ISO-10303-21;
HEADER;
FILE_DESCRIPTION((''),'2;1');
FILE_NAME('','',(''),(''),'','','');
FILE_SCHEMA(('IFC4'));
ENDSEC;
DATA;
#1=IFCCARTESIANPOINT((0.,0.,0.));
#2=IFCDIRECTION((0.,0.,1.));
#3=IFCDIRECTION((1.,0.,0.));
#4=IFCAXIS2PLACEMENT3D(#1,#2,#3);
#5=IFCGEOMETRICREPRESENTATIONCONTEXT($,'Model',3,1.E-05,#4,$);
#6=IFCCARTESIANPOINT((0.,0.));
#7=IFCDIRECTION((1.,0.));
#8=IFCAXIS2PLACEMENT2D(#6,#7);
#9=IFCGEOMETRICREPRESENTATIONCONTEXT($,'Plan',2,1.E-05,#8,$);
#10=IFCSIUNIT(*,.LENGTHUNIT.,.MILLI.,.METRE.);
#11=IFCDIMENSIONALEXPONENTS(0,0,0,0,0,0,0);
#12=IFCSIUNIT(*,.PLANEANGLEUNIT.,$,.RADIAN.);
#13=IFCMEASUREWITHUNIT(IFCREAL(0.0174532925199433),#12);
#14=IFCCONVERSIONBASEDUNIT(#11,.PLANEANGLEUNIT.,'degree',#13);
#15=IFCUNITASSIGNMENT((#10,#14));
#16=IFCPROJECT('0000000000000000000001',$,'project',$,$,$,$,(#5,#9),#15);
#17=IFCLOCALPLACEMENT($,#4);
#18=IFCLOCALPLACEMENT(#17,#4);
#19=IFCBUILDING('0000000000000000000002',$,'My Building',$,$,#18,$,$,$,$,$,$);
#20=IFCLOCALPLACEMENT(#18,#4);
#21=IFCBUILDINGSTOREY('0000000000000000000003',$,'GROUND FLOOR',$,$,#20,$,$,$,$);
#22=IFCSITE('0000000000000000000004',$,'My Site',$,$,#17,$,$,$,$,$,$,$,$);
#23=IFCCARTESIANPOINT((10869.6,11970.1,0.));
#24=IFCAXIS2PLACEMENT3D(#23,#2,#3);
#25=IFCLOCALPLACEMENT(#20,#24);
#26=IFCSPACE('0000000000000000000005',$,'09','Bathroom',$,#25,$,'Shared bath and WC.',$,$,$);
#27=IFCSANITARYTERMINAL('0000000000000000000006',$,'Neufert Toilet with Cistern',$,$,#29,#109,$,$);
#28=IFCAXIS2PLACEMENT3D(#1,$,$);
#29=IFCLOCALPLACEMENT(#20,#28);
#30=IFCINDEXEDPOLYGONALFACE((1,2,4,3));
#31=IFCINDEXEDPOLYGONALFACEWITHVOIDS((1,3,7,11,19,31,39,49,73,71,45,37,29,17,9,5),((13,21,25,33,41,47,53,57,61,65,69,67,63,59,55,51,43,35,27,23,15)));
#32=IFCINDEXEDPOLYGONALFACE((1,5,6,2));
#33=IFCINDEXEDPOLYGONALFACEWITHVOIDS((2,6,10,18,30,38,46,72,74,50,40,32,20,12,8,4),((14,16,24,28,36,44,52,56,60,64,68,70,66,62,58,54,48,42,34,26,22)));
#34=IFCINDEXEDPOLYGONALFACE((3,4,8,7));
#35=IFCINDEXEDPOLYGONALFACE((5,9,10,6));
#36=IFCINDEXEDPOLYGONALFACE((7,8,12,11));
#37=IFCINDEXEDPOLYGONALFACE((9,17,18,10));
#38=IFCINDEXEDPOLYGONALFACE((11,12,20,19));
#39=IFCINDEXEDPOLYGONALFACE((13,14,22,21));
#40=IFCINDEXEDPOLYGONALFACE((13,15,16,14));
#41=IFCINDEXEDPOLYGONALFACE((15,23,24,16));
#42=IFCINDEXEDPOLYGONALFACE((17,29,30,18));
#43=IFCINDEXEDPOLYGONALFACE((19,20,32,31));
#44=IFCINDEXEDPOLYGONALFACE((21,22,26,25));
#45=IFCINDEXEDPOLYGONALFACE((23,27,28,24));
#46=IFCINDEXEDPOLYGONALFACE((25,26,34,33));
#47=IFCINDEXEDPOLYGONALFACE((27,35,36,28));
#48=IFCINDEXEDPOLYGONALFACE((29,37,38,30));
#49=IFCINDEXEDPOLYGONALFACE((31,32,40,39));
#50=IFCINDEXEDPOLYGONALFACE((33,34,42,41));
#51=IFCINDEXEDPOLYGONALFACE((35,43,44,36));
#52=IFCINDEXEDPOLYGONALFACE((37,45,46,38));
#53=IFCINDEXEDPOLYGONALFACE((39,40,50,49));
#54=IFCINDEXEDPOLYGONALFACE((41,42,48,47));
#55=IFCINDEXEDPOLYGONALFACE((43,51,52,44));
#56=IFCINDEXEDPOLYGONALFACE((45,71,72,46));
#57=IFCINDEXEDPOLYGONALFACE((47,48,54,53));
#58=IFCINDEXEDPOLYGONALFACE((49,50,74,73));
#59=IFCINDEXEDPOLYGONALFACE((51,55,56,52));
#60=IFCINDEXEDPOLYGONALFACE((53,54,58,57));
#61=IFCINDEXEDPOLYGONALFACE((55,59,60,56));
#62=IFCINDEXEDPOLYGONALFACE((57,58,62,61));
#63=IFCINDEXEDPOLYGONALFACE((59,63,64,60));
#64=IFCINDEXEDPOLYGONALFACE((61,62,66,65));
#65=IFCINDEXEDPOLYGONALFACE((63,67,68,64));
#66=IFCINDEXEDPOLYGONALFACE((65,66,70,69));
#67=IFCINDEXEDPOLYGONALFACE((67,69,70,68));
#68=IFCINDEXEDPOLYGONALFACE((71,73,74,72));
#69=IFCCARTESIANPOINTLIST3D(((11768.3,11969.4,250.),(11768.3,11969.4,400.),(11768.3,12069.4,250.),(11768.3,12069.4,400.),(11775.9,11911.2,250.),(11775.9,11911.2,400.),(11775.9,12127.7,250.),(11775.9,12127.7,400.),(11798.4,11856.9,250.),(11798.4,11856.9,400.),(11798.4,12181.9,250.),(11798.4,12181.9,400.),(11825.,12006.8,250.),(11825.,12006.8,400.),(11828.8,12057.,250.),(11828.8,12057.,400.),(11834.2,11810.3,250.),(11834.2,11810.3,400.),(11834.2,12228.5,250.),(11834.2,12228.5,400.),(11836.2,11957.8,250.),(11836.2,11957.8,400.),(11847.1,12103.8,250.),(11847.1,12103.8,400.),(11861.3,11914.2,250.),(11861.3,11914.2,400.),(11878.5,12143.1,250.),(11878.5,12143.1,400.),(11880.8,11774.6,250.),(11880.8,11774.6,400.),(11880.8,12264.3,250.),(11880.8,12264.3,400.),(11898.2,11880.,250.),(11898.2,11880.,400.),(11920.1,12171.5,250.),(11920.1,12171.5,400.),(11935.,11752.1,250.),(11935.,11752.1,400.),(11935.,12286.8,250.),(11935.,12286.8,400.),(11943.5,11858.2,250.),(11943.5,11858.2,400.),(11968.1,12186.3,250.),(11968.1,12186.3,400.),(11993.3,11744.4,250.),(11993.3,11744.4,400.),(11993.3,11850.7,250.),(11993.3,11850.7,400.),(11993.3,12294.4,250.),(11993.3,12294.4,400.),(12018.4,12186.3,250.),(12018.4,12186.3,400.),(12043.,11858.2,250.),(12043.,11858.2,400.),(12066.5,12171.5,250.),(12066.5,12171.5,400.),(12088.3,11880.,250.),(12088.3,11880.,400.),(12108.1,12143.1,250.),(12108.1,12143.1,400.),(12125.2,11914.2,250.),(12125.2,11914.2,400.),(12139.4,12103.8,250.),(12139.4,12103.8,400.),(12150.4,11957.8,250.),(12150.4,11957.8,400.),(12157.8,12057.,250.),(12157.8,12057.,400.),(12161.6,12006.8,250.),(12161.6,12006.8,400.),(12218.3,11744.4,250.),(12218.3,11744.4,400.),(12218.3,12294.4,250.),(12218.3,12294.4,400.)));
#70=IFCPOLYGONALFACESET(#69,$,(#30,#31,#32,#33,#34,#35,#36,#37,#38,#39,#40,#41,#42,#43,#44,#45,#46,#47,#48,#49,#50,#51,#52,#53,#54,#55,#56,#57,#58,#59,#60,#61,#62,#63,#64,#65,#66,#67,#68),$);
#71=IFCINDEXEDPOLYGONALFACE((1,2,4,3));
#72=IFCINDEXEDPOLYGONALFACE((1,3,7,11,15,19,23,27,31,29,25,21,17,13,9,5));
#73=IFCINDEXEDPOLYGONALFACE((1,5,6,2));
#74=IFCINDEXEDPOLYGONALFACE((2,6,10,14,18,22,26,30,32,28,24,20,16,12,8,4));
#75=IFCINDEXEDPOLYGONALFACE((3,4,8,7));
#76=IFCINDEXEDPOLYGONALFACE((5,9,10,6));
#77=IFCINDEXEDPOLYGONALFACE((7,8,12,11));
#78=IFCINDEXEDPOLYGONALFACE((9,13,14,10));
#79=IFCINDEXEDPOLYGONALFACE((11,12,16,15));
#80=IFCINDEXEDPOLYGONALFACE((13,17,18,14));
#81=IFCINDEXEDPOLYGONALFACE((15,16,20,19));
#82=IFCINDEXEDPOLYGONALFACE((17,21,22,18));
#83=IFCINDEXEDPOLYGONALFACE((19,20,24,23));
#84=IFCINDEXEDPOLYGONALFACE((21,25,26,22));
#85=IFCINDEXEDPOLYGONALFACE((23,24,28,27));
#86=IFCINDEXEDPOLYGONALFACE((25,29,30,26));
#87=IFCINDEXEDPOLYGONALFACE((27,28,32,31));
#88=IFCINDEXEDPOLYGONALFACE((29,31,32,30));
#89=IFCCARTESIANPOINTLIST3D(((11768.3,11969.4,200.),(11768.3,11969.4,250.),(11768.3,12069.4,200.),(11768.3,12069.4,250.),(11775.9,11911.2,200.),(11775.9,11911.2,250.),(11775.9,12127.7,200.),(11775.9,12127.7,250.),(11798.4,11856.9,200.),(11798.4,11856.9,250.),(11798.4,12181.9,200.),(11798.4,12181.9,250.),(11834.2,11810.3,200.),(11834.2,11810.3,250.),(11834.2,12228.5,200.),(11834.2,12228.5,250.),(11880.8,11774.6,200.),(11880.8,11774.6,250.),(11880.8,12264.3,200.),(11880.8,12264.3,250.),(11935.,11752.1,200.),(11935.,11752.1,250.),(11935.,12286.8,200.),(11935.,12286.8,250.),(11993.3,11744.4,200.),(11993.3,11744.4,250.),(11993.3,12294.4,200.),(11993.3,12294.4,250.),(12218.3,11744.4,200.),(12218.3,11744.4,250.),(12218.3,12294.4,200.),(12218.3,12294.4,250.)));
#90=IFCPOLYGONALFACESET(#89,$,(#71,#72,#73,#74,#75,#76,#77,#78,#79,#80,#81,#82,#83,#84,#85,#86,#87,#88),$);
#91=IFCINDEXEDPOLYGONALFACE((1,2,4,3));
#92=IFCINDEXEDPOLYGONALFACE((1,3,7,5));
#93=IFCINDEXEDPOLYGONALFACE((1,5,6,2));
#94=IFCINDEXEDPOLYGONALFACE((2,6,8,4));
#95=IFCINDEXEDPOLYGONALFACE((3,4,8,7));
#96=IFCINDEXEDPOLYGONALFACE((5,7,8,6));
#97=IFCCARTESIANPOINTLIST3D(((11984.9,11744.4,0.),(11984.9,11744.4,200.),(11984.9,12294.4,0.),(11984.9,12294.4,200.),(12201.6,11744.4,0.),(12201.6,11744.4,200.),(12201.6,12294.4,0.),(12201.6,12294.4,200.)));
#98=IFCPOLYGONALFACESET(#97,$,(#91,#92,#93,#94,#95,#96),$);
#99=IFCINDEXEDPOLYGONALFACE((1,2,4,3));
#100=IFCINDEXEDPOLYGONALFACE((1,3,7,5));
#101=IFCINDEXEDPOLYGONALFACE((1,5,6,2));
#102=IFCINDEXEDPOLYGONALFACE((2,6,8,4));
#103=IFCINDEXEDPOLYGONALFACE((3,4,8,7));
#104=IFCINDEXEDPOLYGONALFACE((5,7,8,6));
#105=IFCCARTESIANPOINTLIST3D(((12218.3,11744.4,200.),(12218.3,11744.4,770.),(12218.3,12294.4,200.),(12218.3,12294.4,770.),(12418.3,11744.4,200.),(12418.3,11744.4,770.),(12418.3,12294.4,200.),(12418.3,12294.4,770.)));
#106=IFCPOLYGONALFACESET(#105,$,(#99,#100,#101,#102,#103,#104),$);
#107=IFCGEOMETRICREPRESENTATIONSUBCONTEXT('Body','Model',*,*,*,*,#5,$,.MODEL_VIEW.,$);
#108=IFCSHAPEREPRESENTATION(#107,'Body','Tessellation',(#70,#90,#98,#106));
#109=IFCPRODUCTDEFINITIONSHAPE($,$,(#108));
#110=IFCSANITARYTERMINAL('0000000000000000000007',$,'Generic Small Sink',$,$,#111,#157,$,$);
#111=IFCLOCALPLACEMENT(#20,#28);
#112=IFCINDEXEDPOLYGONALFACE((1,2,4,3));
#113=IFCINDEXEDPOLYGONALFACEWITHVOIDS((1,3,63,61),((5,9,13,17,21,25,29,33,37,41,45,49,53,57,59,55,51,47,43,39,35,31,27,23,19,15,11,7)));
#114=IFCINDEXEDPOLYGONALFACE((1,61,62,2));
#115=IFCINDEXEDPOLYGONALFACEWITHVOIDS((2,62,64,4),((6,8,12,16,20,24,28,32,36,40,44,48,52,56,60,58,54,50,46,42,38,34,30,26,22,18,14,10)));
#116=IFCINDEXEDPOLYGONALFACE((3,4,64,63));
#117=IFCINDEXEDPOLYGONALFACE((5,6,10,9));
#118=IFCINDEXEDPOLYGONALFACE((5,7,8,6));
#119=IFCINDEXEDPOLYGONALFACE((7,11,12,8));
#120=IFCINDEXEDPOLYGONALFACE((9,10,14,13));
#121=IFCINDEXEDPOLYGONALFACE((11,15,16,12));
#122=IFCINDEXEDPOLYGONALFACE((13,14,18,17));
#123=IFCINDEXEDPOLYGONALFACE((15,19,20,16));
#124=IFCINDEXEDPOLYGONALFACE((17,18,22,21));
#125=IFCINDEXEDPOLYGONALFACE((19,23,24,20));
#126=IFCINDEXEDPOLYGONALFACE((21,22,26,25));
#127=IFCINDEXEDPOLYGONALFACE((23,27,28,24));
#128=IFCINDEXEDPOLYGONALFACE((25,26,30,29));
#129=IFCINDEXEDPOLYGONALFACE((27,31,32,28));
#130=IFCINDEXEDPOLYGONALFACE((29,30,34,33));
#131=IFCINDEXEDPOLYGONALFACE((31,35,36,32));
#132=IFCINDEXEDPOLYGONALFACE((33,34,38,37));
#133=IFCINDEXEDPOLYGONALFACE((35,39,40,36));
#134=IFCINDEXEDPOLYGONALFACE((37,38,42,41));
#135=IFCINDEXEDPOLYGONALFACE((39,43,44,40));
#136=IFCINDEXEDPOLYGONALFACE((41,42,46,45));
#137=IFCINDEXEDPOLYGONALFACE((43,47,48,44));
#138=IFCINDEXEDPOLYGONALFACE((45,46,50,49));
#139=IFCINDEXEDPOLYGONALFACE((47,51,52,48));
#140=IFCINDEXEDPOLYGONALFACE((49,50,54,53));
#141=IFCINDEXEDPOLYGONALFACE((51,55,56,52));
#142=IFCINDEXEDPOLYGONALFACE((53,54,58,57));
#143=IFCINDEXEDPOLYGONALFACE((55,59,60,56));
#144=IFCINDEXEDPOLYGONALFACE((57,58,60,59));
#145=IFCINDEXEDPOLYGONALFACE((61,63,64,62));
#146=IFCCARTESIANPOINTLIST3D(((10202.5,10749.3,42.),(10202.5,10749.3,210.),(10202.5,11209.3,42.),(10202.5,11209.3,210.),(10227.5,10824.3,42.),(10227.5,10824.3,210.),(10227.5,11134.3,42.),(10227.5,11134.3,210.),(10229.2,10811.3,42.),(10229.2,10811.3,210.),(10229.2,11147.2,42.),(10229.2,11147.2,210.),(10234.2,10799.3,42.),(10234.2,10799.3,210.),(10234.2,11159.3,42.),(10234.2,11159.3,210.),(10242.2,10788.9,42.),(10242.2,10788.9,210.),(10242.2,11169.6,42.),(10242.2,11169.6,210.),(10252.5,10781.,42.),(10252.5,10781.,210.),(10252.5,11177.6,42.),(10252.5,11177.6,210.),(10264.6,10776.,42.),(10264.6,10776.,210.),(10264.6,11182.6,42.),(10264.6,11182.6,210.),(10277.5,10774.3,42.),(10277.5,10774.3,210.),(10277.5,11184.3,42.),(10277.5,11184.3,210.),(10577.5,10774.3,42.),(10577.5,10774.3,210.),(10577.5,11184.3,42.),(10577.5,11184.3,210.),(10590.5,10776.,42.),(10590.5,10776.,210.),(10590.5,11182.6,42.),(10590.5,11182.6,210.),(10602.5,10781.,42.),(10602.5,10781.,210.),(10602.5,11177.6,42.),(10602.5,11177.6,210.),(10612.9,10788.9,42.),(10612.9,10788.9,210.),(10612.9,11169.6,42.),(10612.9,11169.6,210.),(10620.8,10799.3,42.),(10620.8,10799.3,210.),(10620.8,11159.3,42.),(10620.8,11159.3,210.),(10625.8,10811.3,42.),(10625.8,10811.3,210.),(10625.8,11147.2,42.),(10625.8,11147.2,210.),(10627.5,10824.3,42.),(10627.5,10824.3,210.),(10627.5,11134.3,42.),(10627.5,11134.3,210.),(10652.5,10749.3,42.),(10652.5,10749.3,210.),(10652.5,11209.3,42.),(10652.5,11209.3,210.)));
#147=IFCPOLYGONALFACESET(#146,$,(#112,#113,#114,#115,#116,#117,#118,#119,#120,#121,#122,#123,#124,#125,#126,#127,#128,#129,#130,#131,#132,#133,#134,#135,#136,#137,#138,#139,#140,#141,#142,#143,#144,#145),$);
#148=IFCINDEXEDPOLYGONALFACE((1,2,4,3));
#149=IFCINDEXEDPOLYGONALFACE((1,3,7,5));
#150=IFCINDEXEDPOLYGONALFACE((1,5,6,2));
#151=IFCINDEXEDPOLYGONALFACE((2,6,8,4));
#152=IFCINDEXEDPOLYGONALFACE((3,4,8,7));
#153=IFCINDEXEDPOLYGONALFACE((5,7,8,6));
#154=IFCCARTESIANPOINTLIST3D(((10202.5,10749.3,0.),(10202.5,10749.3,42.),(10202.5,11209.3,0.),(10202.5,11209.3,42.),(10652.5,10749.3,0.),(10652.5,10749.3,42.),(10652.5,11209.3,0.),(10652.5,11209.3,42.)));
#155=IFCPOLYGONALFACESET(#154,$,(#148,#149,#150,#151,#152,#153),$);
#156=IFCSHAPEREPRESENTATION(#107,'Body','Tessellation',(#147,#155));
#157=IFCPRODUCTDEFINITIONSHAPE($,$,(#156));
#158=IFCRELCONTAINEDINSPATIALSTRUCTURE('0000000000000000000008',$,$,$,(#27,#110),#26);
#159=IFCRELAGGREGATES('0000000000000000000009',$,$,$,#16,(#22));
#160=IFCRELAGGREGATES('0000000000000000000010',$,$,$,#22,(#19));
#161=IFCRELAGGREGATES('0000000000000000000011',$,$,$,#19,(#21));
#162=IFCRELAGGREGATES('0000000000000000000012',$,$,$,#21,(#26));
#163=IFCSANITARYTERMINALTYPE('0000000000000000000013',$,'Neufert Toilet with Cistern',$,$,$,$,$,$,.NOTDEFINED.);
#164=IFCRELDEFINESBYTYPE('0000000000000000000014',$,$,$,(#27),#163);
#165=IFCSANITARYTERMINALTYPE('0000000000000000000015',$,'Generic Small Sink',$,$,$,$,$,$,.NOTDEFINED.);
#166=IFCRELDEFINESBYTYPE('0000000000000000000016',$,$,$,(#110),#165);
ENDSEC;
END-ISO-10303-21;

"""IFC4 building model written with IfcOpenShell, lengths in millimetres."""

from ifc_helpers import new_model, entity, si_unit, converted_unit, frame, frame_2d, origin_with_axes, origin_2d_with_axis, place, context, subcontext, project, spatial, line, arc, indexed_curve, circle_curve, outline, extrude, shape, source, transform, mapped, type_object, type_shapes, element, save


model = new_model("IFC4")

# Units and contexts
model_context = context("Model", 3, precision=1e-05, world=origin_with_axes())
plan_context = context("Plan", 2, precision=1e-05, world=origin_2d_with_axis())
body_context_1 = subcontext(model_context, "Body", "Model", "MODEL_VIEW")
body_context_2 = subcontext(plan_context, "Body", "Plan", "PLAN_VIEW")
ifc_project = project(units=[si_unit("LENGTHUNIT", "METRE", prefix="MILLI"), converted_unit("PLANEANGLEUNIT", "degree", entity("IfcReal", 0.0174532925199433), si_unit("PLANEANGLEUNIT", "RADIAN"), dimensions=[0, 0, 0, 0, 0, 0, 0])], contexts=[model_context, plan_context])

# Site, building, storey
site_placement = place(None, origin_with_axes())
site = spatial("IfcSite", under=ifc_project, at=site_placement, Name="My Site")
building_placement = place(site_placement, origin_with_axes())
building = spatial("IfcBuilding", under=site, at=building_placement, Name="My Building")
storey_placement = place(building_placement, origin_with_axes())
storey = spatial("IfcBuildingStorey", under=building, at=storey_placement, Name="GROUND FLOOR")

# Shared definitions
space_placement = place(storey_placement, frame((10869.6, 11970.1, 0.0), z_axis=(0.0, 0.0, 1.0), x_axis=(1.0, 0.0, 0.0)))
space = spatial("IfcSpace", under=storey, at=space_placement, Name="09", Description="Bathroom", LongName="Shared bath and WC.")

# Sanitary terminals
sanitary_terminal_type_1 = type_object("IfcSanitaryTerminalType", Name="Neufert Toilet with Cistern", PredefinedType="NOTDEFINED")
shared_shape_1 = source(origin_with_axes(), body_context_1, "Body", "SweptSolid", [
    extrude(outline(indexed_curve([(-275.0, -200.0), (275.0, -200.0), (275.0, -425.0), (209.1, -584.1), (50.0, -650.0), (-50.0, -650.0), (-209.1, -584.1), (-275.0, -425.0)], segments=[line(1, 2), line(2, 3), arc(3, 4, 5), line(5, 6), arc(6, 7, 8), line(8, 1)]), holes=[circle_curve(frame_2d((0.0, -425.0)), 168.8)]), frame((0.0, 0.0, 250.0), z_axis=(0.0, 0.0, 1.0), x_axis=(1.0, 0.0, 0.0)), (0.0, 0.0, 1.0), 150.0),
    extrude(outline(indexed_curve([(-275.0, -200.0), (275.0, -200.0), (275.0, -425.0), (209.1, -584.1), (50.0, -650.0), (-50.0, -650.0), (-209.1, -584.1), (-275.0, -425.0)], segments=[line(1, 2), line(2, 3), arc(3, 4, 5), line(5, 6), arc(6, 7, 8), line(8, 1)])), frame((0.0, 0.0, 200.0), z_axis=(0.0, 0.0, 1.0), x_axis=(1.0, 0.0, 0.0)), (0.0, 0.0, 1.0), 50.0),
    extrude(outline(indexed_curve([(-275.0, -216.7), (275.0, -216.7), (275.0, -433.3), (-275.0, -433.3)], segments=[line(1, 2, 3, 4, 1)])), origin_with_axes(), (0.0, 0.0, 1.0), 200.0),
    extrude(outline(indexed_curve([(-275.0, 0.0), (275.0, 0.0), (275.0, -200.0), (-275.0, -200.0)], segments=[line(1, 2, 3, 4, 1)])), frame((0.0, 0.0, 200.0), z_axis=(0.0, 0.0, 1.0), x_axis=(1.0, 0.0, 0.0)), (0.0, 0.0, 1.0), 570.0),
])
shared_shape_2 = source(origin_with_axes(), body_context_2, "Body", "Curve2D", [
    entity("IfcIndexedPolyCurve", entity("IfcCartesianPointList2D", [[-275.0, 0.0], [275.0, 0.0], [275.0, -200.0], [-275.0, -200.0]]), [entity("IfcLineIndex", [1, 2, 3, 4, 1])]),
    entity("IfcIndexedPolyCurve", entity("IfcCartesianPointList2D", [[165.0, -200.0], [192.5, -335.0]])),
    entity("IfcTrimmedCurve", entity("IfcEllipse", entity("IfcAxis2Placement2D", entity("IfcCartesianPoint", [0.0, -335.0]), entity("IfcDirection", [1.0, 0.0])), 192.5, 315.0), [entity("IfcCartesianPoint", [-192.5, -335.0])], [entity("IfcCartesianPoint", [192.5, -335.0])], True, "CARTESIAN"),
    entity("IfcIndexedPolyCurve", entity("IfcCartesianPointList2D", [[-165.0, -200.0], [-192.5, -335.0]])),
    entity("IfcEllipse", entity("IfcAxis2Placement2D", entity("IfcCartesianPoint", [0.0, -452.0]), entity("IfcDirection", [1.0, 0.0])), 131.2, 157.5),
    entity("IfcIndexedPolyCurve", entity("IfcCartesianPointList2D", [[-34.4, -452.0], [-34.4, -429.5], [34.4, -429.5], [34.4, -452.0]])),
    entity("IfcTrimmedCurve", entity("IfcEllipse", entity("IfcAxis2Placement2D", entity("IfcCartesianPoint", [0.0, -452.0]), entity("IfcDirection", [1.0, 0.0])), 34.4, 22.5), [entity("IfcCartesianPoint", [-34.4, -452.0])], [entity("IfcCartesianPoint", [34.4, -452.0])], True, "CARTESIAN"),
])
type_shapes(sanitary_terminal_type_1, [shared_shape_1, shared_shape_2])
sanitary_terminal_1_placement = place(space_placement, frame((1548.7, 49.3, 0.0), z_axis=(0.0, 0.0, 1.0), x_axis=(0.0, -1.0, 0.0)))
element("IfcSanitaryTerminal", 1, at=sanitary_terminal_1_placement, inside=space, type_object=sanitary_terminal_type_1, Name="Neufert Toilet with Cistern", shapes=[
    shape(body_context_1, "Body", "MappedRepresentation", [mapped(shared_shape_1, transform((0.0, 0.0, 0.0), x_axis=(1.0, 0.0, 0.0), y_axis=(0.0, 1.0, 0.0), z_axis=(0.0, 0.0, 1.0), scale=1.0))]),
    shape(body_context_2, "Body", "MappedRepresentation", [mapped(shared_shape_2, transform((0.0, 0.0, 0.0), x_axis=(1.0, 0.0, 0.0), y_axis=(0.0, 1.0, 0.0), z_axis=(0.0, 0.0, 1.0), scale=1.0))]),
])
sanitary_terminal_type_2 = type_object("IfcSanitaryTerminalType", Name="Generic Small Sink", PredefinedType="NOTDEFINED")
shared_indexed_poly_curve = entity("IfcIndexedPolyCurve", entity("IfcCartesianPointList2D", [[0.0, 0.0], [450.0, 0.0], [450.0, 460.0], [0.0, 460.0]]), [entity("IfcLineIndex", [1, 2, 3, 4, 1])])
shared_shape_3 = source(origin_with_axes(), body_context_1, "Body", "SweptSolid", [
    entity("IfcExtrudedAreaSolid", entity("IfcArbitraryProfileDefWithVoids", "AREA", None, shared_indexed_poly_curve, [entity("IfcIndexedPolyCurve", entity("IfcCartesianPointList2D", [[25.0, 75.0], [39.6, 39.6], [75.0, 25.0], [375.0, 25.0], [410.4, 39.6], [425.0, 75.0], [425.0, 385.0], [410.4, 420.4], [375.0, 435.0], [75.0, 435.0], [39.6, 420.4], [25.0, 385.0]]), [entity("IfcLineIndex", [12, 1]), entity("IfcArcIndex", [1, 2, 3]), entity("IfcLineIndex", [3, 4]), entity("IfcArcIndex", [4, 5, 6]), entity("IfcLineIndex", [6, 7]), entity("IfcArcIndex", [7, 8, 9]), entity("IfcLineIndex", [9, 10]), entity("IfcArcIndex", [10, 11, 12]), entity("IfcLineIndex", [12, 1])])]), entity("IfcAxis2Placement3D", entity("IfcCartesianPoint", [-225.0, -460.0, 42.0]), entity("IfcDirection", [0.0, 0.0, 1.0]), entity("IfcDirection", [1.0, 0.0, 0.0])), entity("IfcDirection", [0.0, 0.0, 1.0]), 168.0),
    entity("IfcExtrudedAreaSolid", entity("IfcArbitraryClosedProfileDef", "AREA", None, shared_indexed_poly_curve), entity("IfcAxis2Placement3D", entity("IfcCartesianPoint", [-225.0, -460.0, 0.0]), entity("IfcDirection", [0.0, 0.0, 1.0]), entity("IfcDirection", [1.0, 0.0, 0.0])), entity("IfcDirection", [0.0, 0.0, 1.0]), 42.0),
])
shared_shape_4 = source(origin_with_axes(), body_context_2, "Body", "Curve2D", [
    entity("IfcIndexedPolyCurve", entity("IfcCartesianPointList2D", [[-225.0, -460.0], [225.0, -460.0], [225.0, 0.0], [-225.0, 0.0]]), [entity("IfcLineIndex", [1, 2, 3, 4, 1])]),
    entity("IfcIndexedPolyCurve", entity("IfcCartesianPointList2D", [[-200.0, -385.0], [-185.4, -420.4], [-150.0, -435.0], [150.0, -435.0], [185.4, -420.4], [200.0, -385.0], [200.0, -75.0], [185.4, -39.6], [150.0, -25.0], [-150.0, -25.0], [-185.4, -39.6], [-200.0, -75.0]]), [entity("IfcLineIndex", [12, 1]), entity("IfcArcIndex", [1, 2, 3]), entity("IfcLineIndex", [3, 4]), entity("IfcArcIndex", [4, 5, 6]), entity("IfcLineIndex", [6, 7]), entity("IfcArcIndex", [7, 8, 9]), entity("IfcLineIndex", [9, 10]), entity("IfcArcIndex", [10, 11, 12]), entity("IfcLineIndex", [12, 1])]),
    entity("IfcCircle", entity("IfcAxis2Placement2D", entity("IfcCartesianPoint", [0.0, -125.0])), 25.0),
    entity("IfcIndexedPolyCurve", entity("IfcCartesianPointList2D", [[0.0, -12.5], [0.0, -132.5]])),
])
type_shapes(sanitary_terminal_type_2, [shared_shape_3, shared_shape_4])
sanitary_terminal_2_placement = place(space_placement, frame((-442.1, -1220.8, 0.0), z_axis=(0.0, 0.0, 1.0), x_axis=(-1.0, 0.0, 0.0)))
element("IfcSanitaryTerminal", 2, at=sanitary_terminal_2_placement, inside=space, type_object=sanitary_terminal_type_2, Name="Generic Small Sink", shapes=[
    shape(body_context_1, "Body", "MappedRepresentation", [mapped(shared_shape_3, transform((0.0, 0.0, 0.0), x_axis=(1.0, 0.0, 0.0), y_axis=(0.0, 1.0, 0.0), z_axis=(0.0, 0.0, 1.0), scale=1.0))]),
    shape(body_context_2, "Body", "MappedRepresentation", [mapped(shared_shape_4, transform((0.0, 0.0, 0.0), x_axis=(1.0, 0.0, 0.0), y_axis=(0.0, 1.0, 0.0), z_axis=(0.0, 0.0, 1.0), scale=1.0))]),
])

save(model, "model.ifc")
